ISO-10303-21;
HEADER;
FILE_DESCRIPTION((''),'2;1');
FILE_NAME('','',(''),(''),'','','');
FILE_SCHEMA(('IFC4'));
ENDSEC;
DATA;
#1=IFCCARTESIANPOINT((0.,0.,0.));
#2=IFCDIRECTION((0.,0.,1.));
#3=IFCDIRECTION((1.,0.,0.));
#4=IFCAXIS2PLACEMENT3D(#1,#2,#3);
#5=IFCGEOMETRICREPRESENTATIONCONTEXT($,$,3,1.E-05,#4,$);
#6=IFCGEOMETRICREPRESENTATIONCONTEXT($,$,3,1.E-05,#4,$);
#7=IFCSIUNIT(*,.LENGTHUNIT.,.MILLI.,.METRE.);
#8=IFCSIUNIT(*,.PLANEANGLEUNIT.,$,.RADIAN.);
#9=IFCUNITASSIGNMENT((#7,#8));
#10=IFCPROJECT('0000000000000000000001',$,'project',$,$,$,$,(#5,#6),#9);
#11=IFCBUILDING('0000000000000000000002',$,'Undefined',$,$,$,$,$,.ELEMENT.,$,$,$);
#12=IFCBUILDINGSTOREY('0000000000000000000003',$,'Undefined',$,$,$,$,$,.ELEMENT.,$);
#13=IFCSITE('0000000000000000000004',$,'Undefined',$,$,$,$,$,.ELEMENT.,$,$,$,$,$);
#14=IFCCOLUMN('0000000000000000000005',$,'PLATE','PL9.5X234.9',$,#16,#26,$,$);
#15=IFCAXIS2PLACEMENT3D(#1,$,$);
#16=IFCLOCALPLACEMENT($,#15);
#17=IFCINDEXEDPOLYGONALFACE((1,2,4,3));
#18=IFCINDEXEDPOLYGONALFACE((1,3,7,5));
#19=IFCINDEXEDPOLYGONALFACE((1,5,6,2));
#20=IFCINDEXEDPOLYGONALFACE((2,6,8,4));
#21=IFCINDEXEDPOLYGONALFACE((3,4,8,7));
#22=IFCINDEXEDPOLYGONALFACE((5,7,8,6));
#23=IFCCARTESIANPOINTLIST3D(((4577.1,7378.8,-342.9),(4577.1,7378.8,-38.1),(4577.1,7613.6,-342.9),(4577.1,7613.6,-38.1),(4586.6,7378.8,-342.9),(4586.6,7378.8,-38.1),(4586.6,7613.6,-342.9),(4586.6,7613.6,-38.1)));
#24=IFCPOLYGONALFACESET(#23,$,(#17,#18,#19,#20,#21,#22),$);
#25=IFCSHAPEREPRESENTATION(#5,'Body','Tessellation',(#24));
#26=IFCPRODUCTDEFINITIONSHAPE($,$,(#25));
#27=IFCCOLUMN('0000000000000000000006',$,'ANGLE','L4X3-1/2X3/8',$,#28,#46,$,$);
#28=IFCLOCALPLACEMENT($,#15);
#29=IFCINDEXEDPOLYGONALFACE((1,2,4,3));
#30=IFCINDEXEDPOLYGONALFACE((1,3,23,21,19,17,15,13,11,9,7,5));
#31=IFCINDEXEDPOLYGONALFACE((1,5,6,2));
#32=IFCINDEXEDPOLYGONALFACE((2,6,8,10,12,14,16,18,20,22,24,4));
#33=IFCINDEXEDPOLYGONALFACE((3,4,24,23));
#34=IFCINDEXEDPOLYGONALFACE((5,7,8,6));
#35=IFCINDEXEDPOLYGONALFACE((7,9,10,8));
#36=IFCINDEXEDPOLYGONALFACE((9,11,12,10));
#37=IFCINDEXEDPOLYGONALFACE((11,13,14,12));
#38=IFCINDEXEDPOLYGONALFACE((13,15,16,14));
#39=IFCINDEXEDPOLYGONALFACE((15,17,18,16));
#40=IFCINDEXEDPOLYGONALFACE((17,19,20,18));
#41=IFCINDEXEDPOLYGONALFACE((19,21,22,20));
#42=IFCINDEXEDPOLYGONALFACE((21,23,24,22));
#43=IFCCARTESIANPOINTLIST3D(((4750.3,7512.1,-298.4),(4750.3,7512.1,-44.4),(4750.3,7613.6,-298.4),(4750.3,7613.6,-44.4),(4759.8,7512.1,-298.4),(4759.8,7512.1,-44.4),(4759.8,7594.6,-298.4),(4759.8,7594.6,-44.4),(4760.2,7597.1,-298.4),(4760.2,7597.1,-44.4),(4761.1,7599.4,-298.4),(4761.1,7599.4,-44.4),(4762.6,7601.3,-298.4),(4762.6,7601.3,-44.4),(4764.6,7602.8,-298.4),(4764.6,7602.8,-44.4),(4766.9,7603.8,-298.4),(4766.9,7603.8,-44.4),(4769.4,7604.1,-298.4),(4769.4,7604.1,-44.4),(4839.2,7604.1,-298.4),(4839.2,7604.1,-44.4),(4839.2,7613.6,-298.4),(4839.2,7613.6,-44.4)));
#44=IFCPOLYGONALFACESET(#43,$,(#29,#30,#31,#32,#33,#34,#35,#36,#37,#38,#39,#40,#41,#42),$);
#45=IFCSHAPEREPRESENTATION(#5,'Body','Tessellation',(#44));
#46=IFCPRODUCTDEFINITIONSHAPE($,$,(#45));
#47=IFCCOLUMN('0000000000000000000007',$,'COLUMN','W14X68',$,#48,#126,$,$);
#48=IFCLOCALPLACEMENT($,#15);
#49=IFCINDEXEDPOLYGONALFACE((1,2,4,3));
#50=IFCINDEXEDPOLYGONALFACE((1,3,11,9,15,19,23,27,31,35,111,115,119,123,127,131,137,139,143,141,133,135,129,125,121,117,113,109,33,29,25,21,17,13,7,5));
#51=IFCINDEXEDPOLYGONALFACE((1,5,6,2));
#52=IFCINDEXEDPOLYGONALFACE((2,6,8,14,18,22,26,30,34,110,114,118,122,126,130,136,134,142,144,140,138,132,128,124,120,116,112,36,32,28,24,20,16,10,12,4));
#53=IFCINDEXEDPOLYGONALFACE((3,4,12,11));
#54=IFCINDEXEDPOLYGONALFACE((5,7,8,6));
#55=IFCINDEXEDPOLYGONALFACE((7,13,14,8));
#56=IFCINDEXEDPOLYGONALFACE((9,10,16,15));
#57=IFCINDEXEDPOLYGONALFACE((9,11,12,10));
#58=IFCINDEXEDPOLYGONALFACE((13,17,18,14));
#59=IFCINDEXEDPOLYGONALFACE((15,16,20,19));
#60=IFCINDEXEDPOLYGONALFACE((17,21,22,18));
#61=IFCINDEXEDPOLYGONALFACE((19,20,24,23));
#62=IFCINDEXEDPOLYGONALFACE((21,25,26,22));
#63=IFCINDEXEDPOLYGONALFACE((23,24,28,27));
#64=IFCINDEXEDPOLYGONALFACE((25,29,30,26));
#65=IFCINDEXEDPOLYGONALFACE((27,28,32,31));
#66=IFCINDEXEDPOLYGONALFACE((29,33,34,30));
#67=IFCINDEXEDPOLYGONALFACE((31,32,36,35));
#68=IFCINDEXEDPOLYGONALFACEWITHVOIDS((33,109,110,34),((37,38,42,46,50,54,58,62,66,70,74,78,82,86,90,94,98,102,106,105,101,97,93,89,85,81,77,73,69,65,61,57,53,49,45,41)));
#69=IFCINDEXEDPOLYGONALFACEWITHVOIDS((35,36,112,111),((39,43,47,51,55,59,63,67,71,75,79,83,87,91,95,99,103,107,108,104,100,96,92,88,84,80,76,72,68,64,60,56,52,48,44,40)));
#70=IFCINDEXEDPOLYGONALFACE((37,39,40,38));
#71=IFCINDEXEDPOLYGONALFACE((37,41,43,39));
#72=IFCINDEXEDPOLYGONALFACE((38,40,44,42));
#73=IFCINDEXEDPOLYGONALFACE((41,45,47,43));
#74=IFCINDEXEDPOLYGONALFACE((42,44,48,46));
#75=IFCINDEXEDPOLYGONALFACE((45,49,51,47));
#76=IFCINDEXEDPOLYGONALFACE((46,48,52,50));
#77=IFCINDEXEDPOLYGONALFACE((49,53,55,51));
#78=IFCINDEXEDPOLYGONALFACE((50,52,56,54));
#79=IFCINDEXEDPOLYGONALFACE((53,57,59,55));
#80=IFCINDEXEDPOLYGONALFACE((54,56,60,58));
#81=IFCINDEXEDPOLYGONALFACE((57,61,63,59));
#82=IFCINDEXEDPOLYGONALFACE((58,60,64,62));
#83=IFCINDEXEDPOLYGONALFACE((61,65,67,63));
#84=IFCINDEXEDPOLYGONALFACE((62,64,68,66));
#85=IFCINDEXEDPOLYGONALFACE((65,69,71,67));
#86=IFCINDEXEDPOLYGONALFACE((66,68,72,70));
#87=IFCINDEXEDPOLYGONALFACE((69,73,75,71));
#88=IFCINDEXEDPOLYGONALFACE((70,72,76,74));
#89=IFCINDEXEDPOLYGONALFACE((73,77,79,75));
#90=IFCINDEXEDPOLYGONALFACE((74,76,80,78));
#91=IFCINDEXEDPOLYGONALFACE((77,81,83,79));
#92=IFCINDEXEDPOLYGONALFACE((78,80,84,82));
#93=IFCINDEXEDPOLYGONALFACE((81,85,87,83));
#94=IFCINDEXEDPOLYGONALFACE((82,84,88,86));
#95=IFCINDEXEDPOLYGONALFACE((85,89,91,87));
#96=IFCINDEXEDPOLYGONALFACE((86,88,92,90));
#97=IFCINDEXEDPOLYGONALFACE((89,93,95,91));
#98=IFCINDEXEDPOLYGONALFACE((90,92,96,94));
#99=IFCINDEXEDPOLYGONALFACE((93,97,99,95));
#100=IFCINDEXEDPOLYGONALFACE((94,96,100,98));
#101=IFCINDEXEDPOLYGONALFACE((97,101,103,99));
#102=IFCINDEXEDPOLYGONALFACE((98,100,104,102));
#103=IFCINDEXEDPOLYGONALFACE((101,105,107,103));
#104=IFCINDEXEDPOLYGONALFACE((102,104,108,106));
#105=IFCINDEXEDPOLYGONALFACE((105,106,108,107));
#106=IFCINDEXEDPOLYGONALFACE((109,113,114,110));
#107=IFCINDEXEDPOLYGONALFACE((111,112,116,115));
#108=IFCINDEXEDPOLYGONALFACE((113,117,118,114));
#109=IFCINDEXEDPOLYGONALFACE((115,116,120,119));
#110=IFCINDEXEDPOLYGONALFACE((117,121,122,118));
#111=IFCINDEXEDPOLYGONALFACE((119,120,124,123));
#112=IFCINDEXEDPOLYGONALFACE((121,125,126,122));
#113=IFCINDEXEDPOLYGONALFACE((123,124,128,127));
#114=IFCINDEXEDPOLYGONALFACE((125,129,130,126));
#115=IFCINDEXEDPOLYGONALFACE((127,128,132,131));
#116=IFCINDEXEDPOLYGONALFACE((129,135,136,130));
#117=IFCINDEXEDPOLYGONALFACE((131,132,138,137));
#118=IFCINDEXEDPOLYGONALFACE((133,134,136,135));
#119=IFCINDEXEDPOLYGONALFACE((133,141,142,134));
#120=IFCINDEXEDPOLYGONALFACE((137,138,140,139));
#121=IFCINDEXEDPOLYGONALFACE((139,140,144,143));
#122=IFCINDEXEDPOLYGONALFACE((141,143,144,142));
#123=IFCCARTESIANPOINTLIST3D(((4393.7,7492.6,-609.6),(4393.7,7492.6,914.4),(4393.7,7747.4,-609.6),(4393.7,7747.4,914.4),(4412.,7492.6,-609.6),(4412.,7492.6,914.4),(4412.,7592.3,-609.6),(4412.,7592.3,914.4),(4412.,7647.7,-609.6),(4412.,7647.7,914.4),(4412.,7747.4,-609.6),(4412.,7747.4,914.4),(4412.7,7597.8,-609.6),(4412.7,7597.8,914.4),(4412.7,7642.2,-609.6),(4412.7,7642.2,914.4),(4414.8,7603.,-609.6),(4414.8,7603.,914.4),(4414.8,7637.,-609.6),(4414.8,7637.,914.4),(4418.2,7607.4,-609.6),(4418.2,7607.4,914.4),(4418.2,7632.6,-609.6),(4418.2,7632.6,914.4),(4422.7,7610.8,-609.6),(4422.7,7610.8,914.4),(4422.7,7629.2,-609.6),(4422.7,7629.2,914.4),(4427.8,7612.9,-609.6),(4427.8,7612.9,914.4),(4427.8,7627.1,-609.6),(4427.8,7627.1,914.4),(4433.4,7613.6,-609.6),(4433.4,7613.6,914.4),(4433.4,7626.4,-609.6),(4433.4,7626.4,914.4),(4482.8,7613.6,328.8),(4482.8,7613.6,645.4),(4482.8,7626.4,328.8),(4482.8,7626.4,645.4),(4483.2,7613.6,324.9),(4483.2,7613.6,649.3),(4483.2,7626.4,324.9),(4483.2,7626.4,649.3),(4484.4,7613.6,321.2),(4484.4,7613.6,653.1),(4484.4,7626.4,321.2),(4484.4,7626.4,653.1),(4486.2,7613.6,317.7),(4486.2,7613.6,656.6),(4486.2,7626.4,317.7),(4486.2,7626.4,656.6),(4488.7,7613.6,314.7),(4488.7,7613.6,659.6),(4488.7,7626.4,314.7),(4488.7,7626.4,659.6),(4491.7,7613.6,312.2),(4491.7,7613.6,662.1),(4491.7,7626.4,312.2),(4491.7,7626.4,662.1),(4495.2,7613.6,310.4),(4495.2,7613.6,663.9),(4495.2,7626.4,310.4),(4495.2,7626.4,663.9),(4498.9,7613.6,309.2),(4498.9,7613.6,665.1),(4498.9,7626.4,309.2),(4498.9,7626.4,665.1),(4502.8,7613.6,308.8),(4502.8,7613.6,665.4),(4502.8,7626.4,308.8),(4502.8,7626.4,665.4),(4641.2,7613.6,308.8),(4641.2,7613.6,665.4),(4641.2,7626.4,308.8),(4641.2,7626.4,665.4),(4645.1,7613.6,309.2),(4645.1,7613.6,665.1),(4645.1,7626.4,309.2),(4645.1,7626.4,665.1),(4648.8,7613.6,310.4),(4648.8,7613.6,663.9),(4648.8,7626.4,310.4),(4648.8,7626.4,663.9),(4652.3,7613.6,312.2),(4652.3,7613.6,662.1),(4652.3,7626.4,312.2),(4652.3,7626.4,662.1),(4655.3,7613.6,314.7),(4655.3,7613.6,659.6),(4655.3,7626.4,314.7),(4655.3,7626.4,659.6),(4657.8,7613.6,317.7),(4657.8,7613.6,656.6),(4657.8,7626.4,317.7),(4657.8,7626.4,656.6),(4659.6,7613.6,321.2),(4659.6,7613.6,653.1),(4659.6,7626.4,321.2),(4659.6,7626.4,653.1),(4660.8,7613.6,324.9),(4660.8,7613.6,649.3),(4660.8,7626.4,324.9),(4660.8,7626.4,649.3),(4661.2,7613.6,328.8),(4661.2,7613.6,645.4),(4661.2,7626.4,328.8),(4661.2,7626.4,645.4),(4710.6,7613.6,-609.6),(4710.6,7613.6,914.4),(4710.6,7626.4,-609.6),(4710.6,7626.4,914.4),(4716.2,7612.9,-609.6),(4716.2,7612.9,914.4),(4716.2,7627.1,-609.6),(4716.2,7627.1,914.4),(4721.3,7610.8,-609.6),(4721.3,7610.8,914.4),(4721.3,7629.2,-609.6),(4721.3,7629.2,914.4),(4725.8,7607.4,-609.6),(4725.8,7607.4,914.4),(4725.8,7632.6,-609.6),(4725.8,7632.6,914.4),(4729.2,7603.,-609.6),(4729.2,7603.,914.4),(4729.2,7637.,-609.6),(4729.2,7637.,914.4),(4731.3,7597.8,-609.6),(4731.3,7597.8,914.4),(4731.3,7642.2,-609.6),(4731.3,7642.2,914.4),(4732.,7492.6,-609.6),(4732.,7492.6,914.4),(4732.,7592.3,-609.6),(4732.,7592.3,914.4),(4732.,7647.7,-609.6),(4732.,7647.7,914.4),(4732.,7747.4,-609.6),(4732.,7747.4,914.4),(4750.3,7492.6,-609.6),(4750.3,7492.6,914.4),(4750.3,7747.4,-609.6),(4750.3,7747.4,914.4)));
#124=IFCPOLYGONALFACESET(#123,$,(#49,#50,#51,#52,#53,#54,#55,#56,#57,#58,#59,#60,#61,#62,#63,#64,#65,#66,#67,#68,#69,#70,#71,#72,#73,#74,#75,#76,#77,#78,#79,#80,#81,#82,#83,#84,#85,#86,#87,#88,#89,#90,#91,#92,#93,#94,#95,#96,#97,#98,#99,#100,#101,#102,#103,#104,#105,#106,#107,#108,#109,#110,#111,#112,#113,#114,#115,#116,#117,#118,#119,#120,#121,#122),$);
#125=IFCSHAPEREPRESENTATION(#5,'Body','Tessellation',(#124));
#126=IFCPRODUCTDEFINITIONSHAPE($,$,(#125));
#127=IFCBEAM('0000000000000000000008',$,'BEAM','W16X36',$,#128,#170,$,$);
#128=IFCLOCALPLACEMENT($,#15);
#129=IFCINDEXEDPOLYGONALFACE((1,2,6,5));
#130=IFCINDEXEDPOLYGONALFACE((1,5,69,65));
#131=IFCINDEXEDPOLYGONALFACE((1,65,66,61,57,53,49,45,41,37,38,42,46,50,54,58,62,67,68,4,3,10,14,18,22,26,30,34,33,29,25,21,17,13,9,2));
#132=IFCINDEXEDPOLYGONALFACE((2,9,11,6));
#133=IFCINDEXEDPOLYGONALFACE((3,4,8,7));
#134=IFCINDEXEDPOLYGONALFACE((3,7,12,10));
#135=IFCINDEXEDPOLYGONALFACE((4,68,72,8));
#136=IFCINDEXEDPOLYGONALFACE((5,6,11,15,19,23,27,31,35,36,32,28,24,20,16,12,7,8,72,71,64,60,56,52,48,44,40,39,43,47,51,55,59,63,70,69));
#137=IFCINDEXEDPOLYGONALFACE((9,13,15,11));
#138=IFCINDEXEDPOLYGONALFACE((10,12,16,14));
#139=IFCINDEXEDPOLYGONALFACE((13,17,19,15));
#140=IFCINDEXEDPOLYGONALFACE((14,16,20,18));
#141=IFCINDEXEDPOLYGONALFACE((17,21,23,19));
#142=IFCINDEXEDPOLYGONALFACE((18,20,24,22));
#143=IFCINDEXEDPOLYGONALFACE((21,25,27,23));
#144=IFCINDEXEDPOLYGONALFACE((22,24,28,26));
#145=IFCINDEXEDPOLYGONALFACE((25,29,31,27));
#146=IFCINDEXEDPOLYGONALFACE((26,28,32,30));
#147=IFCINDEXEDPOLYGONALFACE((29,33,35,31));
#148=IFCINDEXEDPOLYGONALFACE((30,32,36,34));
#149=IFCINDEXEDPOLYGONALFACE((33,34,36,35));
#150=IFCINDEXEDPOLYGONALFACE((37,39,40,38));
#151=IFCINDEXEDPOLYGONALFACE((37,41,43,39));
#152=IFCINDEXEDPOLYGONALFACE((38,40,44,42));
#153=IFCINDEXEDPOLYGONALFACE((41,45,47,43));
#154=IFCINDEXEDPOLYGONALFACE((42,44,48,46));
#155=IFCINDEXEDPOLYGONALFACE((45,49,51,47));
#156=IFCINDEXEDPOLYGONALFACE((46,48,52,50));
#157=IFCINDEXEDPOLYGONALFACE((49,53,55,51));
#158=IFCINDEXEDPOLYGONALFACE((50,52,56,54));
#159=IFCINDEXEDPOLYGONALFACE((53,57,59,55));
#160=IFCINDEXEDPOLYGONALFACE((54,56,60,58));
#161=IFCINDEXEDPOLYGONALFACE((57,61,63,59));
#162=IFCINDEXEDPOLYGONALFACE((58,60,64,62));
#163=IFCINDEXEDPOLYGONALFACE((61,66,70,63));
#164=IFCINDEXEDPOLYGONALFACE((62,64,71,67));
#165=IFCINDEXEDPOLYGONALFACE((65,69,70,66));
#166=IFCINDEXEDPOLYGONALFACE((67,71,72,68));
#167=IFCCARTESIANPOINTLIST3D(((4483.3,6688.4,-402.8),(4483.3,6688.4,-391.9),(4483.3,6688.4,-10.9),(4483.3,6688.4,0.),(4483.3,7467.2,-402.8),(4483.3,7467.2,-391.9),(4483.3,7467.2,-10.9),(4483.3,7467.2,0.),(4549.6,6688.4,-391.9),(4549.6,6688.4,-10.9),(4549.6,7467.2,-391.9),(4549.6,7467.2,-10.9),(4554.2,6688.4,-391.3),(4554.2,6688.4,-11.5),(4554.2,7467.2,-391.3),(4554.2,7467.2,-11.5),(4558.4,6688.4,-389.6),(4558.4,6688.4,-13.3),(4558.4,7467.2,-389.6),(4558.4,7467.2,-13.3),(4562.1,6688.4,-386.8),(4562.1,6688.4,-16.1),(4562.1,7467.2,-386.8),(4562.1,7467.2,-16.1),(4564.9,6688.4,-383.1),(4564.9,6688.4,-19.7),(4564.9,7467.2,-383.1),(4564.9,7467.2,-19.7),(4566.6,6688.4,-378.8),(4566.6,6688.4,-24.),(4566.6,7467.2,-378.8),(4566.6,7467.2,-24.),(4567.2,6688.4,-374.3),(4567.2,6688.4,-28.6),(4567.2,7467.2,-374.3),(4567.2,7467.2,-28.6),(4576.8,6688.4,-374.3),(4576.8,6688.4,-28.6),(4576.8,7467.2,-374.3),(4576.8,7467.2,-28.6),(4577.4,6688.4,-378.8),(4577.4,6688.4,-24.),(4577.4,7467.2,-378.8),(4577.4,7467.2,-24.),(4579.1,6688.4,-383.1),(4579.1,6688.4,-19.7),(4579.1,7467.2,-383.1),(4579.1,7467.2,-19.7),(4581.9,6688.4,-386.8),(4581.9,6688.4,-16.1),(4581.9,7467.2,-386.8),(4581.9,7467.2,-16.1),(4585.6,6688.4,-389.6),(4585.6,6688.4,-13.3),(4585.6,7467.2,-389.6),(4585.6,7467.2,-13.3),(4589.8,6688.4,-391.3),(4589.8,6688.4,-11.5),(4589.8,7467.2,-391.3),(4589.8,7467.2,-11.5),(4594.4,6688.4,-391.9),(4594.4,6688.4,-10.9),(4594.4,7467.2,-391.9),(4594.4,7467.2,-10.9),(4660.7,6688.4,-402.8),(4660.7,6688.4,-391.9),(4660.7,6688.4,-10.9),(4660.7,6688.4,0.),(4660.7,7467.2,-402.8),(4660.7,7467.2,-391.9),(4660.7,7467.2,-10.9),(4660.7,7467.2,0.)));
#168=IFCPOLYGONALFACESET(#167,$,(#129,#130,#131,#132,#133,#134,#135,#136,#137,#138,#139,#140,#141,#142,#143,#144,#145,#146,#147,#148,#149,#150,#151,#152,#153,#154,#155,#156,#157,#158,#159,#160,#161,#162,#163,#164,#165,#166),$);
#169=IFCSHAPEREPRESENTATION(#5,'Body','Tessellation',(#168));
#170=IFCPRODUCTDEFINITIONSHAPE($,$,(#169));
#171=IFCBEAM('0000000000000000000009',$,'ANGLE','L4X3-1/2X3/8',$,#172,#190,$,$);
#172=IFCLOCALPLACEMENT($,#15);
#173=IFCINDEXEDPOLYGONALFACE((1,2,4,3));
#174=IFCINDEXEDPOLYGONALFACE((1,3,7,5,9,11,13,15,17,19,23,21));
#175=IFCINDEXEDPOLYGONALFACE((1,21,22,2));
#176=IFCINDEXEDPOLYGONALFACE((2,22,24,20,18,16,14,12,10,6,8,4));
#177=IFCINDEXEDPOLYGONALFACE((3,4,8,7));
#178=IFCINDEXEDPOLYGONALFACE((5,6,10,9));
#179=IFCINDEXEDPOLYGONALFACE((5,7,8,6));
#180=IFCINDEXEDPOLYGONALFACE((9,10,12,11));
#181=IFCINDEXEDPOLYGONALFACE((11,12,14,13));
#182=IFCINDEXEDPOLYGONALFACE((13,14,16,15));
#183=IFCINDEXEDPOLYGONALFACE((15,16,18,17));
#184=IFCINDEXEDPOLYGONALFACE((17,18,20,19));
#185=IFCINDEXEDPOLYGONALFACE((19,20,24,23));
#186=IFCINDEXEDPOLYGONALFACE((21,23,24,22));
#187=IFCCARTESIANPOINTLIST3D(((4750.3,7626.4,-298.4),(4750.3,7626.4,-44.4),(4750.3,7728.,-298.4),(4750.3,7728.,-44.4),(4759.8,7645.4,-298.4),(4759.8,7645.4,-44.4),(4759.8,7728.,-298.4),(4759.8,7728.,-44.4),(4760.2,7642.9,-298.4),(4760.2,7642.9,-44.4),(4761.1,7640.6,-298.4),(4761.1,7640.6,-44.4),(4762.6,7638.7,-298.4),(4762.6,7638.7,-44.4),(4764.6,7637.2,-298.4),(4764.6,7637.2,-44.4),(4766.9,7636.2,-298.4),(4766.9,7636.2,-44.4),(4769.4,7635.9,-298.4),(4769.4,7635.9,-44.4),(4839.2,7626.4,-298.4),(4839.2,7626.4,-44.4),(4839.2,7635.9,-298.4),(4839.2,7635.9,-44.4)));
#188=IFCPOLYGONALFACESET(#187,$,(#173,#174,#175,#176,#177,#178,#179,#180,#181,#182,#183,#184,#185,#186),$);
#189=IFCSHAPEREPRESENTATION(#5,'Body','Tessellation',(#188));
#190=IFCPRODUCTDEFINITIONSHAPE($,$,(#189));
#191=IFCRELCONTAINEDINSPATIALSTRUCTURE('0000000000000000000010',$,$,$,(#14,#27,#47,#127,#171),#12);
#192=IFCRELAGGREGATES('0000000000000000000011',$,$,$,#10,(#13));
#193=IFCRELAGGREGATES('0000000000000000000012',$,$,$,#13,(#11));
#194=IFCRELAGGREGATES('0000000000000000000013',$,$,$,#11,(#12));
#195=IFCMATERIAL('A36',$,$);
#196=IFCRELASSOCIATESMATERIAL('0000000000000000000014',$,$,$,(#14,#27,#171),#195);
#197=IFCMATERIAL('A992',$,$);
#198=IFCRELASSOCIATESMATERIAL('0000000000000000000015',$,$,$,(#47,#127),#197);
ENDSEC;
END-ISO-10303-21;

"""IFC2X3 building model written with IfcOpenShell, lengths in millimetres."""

from ifc_helpers import new_model, si_unit, frame, origin_with_axes, origin_2d_with_axis, place, context, project, spatial, polyline, rectangle, i_section, l_section, outline, extrude, clip, halfspace, material, element, save


model = new_model("IFC2X3")

# Units and contexts
context_of_model_1 = context(None, 3, precision=1e-05, world=origin_with_axes())
context_of_model_2 = context(None, 3, precision=1e-05, world=origin_with_axes())
ifc_project = project(units=[si_unit("LENGTHUNIT", "METRE", prefix="MILLI"), si_unit("PLANEANGLEUNIT", "RADIAN")], contexts=[context_of_model_1, context_of_model_2])

# Site, building, storey
site = spatial("IfcSite", under=ifc_project, Name="Undefined", CompositionType="ELEMENT")
building = spatial("IfcBuilding", under=site, Name="Undefined", CompositionType="ELEMENT")
storey = spatial("IfcBuildingStorey", under=building, Name="Undefined", CompositionType="ELEMENT")

# Columns
ifc_material_1 = material(Name="A36")
column_1_placement = place(None, frame((4581.8, 7496.2, -342.9), z_axis=(-1.0, 0.0, 0.0), x_axis=(0.0, 0.0, 1.0)))
element("IfcColumn", 1, at=column_1_placement, inside=storey, material=ifc_material_1, Name="PLATE", Description="PL9.5X234.9", context=context_of_model_1, shape_type="SweptSolid", body=[
    extrude(rectangle(XDim=9.5, YDim=234.9, at=origin_2d_with_axis()), frame((0.0, 0.0, 0.0), z_axis=(-1.0, 0.0, 0.0), x_axis=(0.0, 0.0, 1.0)), (0.0, 0.0, -1.0), 304.8),
])
column_2_placement = place(None, frame((4794.8, 7562.9, -298.4), z_axis=(1.0, 0.0, 0.0), x_axis=(0.0, 0.0, 1.0)))
element("IfcColumn", 2, at=column_2_placement, inside=storey, material=ifc_material_1, Name="ANGLE", Description="L4X3-1/2X3/8", context=context_of_model_1, shape_type="SweptSolid", body=[
    extrude(l_section(Depth=101.6, Width=88.9, Thickness=9.5, FilletRadius=9.5, at=origin_2d_with_axis()), frame((0.0, 0.0, 0.0), z_axis=(-1.0, 0.0, 0.0), x_axis=(0.0, 0.0, 1.0)), (0.0, 0.0, -1.0), 254.0),
])

# Column, opening
ifc_material_2 = material(Name="A992")
column_3_placement = place(None, frame((4572.0, 7620.0, -609.6), z_axis=(0.0, -1.0, 0.0), x_axis=(0.0, 0.0, 1.0)))
column_3 = element("IfcColumn", 3, at=column_3_placement, inside=storey, material=ifc_material_2, Name="COLUMN", Description="W14X68", context=context_of_model_1, shape_type="SweptSolid", body=[
    extrude(i_section(OverallWidth=254.9, OverallDepth=356.6, WebThickness=12.7, FlangeThickness=18.3, FilletRadius=21.4, at=origin_2d_with_axis()), frame((0.0, 0.0, 0.0), z_axis=(-1.0, 0.0, 0.0), x_axis=(0.0, 0.0, 1.0)), (0.0, 0.0, -1.0), 1524.0),
])
opening_1_placement = place(None, frame((4661.2, 7490.1, 308.8), z_axis=(0.0, 1.0, 0.0), x_axis=(-1.0, 0.0, 0.0)))
element("IfcOpeningElement", 4, at=opening_1_placement, cuts=column_3, context=context_of_model_1, shape_type="SweptSolid", body=[
    extrude(outline(polyline([(0.4, 16.1), (0.0, 20.0), (0.0, 336.6), (0.4, 340.5), (1.5, 344.3), (3.4, 347.7), (5.9, 350.8), (8.9, 353.2), (12.3, 355.1), (16.1, 356.2), (20.0, 356.6), (158.3, 356.6), (162.2, 356.2), (166.0, 355.1), (169.4, 353.2), (172.5, 350.8), (174.9, 347.7), (176.8, 344.3), (177.9, 340.5), (178.3, 336.6), (178.3, 20.0), (177.9, 16.1), (176.8, 12.3), (174.9, 8.9), (172.5, 5.9), (169.4, 3.4), (166.0, 1.5), (162.2, 0.4), (158.3, 0.0), (20.0, 0.0), (16.1, 0.4), (12.3, 1.5), (8.9, 3.4), (5.9, 5.9), (3.4, 8.9), (1.5, 12.3), (0.4, 16.1)])), origin_with_axes(), (0.0, 0.0, 1.0), 259.9),
])

# Beams
beam_1_placement = place(None, frame((4572.0, 6688.4, -201.4), z_axis=(1.0, 0.0, 0.0), x_axis=(0.0, 1.0, 0.0)))
element("IfcBeam", 5, at=beam_1_placement, inside=storey, material=ifc_material_2, Name="BEAM", Description="W16X36", context=context_of_model_1, shape_type="Clipping", body=[
    clip(extrude(i_section(OverallWidth=177.4, OverallDepth=402.8, WebThickness=9.5, FlangeThickness=10.9, FilletRadius=17.7, at=origin_2d_with_axis()), frame((0.0, 0.0, 0.0), z_axis=(-1.0, 0.0, 0.0), x_axis=(0.0, 0.0, 1.0)), (0.0, 0.0, -1.0), 2278.8), halfspace(frame((778.8, 301.4, 0.0), z_axis=(1.0, 0.0, 0.0), x_axis=(0.0, 0.0, -1.0)), False)),
])
beam_2_placement = place(None, frame((4794.8, 7677.1, -44.5), z_axis=(1.0, 0.0, 0.0), x_axis=(0.0, 0.0, -1.0)))
element("IfcBeam", 6, at=beam_2_placement, inside=storey, material=ifc_material_1, Name="ANGLE", Description="L4X3-1/2X3/8", context=context_of_model_1, shape_type="SweptSolid", body=[
    extrude(l_section(Depth=101.6, Width=88.9, Thickness=9.5, FilletRadius=9.5, at=origin_2d_with_axis()), frame((0.0, 0.0, 0.0), z_axis=(-1.0, 0.0, 0.0), x_axis=(0.0, 0.0, 1.0)), (0.0, 0.0, -1.0), 254.0),
])

save(model, "model.ifc")
